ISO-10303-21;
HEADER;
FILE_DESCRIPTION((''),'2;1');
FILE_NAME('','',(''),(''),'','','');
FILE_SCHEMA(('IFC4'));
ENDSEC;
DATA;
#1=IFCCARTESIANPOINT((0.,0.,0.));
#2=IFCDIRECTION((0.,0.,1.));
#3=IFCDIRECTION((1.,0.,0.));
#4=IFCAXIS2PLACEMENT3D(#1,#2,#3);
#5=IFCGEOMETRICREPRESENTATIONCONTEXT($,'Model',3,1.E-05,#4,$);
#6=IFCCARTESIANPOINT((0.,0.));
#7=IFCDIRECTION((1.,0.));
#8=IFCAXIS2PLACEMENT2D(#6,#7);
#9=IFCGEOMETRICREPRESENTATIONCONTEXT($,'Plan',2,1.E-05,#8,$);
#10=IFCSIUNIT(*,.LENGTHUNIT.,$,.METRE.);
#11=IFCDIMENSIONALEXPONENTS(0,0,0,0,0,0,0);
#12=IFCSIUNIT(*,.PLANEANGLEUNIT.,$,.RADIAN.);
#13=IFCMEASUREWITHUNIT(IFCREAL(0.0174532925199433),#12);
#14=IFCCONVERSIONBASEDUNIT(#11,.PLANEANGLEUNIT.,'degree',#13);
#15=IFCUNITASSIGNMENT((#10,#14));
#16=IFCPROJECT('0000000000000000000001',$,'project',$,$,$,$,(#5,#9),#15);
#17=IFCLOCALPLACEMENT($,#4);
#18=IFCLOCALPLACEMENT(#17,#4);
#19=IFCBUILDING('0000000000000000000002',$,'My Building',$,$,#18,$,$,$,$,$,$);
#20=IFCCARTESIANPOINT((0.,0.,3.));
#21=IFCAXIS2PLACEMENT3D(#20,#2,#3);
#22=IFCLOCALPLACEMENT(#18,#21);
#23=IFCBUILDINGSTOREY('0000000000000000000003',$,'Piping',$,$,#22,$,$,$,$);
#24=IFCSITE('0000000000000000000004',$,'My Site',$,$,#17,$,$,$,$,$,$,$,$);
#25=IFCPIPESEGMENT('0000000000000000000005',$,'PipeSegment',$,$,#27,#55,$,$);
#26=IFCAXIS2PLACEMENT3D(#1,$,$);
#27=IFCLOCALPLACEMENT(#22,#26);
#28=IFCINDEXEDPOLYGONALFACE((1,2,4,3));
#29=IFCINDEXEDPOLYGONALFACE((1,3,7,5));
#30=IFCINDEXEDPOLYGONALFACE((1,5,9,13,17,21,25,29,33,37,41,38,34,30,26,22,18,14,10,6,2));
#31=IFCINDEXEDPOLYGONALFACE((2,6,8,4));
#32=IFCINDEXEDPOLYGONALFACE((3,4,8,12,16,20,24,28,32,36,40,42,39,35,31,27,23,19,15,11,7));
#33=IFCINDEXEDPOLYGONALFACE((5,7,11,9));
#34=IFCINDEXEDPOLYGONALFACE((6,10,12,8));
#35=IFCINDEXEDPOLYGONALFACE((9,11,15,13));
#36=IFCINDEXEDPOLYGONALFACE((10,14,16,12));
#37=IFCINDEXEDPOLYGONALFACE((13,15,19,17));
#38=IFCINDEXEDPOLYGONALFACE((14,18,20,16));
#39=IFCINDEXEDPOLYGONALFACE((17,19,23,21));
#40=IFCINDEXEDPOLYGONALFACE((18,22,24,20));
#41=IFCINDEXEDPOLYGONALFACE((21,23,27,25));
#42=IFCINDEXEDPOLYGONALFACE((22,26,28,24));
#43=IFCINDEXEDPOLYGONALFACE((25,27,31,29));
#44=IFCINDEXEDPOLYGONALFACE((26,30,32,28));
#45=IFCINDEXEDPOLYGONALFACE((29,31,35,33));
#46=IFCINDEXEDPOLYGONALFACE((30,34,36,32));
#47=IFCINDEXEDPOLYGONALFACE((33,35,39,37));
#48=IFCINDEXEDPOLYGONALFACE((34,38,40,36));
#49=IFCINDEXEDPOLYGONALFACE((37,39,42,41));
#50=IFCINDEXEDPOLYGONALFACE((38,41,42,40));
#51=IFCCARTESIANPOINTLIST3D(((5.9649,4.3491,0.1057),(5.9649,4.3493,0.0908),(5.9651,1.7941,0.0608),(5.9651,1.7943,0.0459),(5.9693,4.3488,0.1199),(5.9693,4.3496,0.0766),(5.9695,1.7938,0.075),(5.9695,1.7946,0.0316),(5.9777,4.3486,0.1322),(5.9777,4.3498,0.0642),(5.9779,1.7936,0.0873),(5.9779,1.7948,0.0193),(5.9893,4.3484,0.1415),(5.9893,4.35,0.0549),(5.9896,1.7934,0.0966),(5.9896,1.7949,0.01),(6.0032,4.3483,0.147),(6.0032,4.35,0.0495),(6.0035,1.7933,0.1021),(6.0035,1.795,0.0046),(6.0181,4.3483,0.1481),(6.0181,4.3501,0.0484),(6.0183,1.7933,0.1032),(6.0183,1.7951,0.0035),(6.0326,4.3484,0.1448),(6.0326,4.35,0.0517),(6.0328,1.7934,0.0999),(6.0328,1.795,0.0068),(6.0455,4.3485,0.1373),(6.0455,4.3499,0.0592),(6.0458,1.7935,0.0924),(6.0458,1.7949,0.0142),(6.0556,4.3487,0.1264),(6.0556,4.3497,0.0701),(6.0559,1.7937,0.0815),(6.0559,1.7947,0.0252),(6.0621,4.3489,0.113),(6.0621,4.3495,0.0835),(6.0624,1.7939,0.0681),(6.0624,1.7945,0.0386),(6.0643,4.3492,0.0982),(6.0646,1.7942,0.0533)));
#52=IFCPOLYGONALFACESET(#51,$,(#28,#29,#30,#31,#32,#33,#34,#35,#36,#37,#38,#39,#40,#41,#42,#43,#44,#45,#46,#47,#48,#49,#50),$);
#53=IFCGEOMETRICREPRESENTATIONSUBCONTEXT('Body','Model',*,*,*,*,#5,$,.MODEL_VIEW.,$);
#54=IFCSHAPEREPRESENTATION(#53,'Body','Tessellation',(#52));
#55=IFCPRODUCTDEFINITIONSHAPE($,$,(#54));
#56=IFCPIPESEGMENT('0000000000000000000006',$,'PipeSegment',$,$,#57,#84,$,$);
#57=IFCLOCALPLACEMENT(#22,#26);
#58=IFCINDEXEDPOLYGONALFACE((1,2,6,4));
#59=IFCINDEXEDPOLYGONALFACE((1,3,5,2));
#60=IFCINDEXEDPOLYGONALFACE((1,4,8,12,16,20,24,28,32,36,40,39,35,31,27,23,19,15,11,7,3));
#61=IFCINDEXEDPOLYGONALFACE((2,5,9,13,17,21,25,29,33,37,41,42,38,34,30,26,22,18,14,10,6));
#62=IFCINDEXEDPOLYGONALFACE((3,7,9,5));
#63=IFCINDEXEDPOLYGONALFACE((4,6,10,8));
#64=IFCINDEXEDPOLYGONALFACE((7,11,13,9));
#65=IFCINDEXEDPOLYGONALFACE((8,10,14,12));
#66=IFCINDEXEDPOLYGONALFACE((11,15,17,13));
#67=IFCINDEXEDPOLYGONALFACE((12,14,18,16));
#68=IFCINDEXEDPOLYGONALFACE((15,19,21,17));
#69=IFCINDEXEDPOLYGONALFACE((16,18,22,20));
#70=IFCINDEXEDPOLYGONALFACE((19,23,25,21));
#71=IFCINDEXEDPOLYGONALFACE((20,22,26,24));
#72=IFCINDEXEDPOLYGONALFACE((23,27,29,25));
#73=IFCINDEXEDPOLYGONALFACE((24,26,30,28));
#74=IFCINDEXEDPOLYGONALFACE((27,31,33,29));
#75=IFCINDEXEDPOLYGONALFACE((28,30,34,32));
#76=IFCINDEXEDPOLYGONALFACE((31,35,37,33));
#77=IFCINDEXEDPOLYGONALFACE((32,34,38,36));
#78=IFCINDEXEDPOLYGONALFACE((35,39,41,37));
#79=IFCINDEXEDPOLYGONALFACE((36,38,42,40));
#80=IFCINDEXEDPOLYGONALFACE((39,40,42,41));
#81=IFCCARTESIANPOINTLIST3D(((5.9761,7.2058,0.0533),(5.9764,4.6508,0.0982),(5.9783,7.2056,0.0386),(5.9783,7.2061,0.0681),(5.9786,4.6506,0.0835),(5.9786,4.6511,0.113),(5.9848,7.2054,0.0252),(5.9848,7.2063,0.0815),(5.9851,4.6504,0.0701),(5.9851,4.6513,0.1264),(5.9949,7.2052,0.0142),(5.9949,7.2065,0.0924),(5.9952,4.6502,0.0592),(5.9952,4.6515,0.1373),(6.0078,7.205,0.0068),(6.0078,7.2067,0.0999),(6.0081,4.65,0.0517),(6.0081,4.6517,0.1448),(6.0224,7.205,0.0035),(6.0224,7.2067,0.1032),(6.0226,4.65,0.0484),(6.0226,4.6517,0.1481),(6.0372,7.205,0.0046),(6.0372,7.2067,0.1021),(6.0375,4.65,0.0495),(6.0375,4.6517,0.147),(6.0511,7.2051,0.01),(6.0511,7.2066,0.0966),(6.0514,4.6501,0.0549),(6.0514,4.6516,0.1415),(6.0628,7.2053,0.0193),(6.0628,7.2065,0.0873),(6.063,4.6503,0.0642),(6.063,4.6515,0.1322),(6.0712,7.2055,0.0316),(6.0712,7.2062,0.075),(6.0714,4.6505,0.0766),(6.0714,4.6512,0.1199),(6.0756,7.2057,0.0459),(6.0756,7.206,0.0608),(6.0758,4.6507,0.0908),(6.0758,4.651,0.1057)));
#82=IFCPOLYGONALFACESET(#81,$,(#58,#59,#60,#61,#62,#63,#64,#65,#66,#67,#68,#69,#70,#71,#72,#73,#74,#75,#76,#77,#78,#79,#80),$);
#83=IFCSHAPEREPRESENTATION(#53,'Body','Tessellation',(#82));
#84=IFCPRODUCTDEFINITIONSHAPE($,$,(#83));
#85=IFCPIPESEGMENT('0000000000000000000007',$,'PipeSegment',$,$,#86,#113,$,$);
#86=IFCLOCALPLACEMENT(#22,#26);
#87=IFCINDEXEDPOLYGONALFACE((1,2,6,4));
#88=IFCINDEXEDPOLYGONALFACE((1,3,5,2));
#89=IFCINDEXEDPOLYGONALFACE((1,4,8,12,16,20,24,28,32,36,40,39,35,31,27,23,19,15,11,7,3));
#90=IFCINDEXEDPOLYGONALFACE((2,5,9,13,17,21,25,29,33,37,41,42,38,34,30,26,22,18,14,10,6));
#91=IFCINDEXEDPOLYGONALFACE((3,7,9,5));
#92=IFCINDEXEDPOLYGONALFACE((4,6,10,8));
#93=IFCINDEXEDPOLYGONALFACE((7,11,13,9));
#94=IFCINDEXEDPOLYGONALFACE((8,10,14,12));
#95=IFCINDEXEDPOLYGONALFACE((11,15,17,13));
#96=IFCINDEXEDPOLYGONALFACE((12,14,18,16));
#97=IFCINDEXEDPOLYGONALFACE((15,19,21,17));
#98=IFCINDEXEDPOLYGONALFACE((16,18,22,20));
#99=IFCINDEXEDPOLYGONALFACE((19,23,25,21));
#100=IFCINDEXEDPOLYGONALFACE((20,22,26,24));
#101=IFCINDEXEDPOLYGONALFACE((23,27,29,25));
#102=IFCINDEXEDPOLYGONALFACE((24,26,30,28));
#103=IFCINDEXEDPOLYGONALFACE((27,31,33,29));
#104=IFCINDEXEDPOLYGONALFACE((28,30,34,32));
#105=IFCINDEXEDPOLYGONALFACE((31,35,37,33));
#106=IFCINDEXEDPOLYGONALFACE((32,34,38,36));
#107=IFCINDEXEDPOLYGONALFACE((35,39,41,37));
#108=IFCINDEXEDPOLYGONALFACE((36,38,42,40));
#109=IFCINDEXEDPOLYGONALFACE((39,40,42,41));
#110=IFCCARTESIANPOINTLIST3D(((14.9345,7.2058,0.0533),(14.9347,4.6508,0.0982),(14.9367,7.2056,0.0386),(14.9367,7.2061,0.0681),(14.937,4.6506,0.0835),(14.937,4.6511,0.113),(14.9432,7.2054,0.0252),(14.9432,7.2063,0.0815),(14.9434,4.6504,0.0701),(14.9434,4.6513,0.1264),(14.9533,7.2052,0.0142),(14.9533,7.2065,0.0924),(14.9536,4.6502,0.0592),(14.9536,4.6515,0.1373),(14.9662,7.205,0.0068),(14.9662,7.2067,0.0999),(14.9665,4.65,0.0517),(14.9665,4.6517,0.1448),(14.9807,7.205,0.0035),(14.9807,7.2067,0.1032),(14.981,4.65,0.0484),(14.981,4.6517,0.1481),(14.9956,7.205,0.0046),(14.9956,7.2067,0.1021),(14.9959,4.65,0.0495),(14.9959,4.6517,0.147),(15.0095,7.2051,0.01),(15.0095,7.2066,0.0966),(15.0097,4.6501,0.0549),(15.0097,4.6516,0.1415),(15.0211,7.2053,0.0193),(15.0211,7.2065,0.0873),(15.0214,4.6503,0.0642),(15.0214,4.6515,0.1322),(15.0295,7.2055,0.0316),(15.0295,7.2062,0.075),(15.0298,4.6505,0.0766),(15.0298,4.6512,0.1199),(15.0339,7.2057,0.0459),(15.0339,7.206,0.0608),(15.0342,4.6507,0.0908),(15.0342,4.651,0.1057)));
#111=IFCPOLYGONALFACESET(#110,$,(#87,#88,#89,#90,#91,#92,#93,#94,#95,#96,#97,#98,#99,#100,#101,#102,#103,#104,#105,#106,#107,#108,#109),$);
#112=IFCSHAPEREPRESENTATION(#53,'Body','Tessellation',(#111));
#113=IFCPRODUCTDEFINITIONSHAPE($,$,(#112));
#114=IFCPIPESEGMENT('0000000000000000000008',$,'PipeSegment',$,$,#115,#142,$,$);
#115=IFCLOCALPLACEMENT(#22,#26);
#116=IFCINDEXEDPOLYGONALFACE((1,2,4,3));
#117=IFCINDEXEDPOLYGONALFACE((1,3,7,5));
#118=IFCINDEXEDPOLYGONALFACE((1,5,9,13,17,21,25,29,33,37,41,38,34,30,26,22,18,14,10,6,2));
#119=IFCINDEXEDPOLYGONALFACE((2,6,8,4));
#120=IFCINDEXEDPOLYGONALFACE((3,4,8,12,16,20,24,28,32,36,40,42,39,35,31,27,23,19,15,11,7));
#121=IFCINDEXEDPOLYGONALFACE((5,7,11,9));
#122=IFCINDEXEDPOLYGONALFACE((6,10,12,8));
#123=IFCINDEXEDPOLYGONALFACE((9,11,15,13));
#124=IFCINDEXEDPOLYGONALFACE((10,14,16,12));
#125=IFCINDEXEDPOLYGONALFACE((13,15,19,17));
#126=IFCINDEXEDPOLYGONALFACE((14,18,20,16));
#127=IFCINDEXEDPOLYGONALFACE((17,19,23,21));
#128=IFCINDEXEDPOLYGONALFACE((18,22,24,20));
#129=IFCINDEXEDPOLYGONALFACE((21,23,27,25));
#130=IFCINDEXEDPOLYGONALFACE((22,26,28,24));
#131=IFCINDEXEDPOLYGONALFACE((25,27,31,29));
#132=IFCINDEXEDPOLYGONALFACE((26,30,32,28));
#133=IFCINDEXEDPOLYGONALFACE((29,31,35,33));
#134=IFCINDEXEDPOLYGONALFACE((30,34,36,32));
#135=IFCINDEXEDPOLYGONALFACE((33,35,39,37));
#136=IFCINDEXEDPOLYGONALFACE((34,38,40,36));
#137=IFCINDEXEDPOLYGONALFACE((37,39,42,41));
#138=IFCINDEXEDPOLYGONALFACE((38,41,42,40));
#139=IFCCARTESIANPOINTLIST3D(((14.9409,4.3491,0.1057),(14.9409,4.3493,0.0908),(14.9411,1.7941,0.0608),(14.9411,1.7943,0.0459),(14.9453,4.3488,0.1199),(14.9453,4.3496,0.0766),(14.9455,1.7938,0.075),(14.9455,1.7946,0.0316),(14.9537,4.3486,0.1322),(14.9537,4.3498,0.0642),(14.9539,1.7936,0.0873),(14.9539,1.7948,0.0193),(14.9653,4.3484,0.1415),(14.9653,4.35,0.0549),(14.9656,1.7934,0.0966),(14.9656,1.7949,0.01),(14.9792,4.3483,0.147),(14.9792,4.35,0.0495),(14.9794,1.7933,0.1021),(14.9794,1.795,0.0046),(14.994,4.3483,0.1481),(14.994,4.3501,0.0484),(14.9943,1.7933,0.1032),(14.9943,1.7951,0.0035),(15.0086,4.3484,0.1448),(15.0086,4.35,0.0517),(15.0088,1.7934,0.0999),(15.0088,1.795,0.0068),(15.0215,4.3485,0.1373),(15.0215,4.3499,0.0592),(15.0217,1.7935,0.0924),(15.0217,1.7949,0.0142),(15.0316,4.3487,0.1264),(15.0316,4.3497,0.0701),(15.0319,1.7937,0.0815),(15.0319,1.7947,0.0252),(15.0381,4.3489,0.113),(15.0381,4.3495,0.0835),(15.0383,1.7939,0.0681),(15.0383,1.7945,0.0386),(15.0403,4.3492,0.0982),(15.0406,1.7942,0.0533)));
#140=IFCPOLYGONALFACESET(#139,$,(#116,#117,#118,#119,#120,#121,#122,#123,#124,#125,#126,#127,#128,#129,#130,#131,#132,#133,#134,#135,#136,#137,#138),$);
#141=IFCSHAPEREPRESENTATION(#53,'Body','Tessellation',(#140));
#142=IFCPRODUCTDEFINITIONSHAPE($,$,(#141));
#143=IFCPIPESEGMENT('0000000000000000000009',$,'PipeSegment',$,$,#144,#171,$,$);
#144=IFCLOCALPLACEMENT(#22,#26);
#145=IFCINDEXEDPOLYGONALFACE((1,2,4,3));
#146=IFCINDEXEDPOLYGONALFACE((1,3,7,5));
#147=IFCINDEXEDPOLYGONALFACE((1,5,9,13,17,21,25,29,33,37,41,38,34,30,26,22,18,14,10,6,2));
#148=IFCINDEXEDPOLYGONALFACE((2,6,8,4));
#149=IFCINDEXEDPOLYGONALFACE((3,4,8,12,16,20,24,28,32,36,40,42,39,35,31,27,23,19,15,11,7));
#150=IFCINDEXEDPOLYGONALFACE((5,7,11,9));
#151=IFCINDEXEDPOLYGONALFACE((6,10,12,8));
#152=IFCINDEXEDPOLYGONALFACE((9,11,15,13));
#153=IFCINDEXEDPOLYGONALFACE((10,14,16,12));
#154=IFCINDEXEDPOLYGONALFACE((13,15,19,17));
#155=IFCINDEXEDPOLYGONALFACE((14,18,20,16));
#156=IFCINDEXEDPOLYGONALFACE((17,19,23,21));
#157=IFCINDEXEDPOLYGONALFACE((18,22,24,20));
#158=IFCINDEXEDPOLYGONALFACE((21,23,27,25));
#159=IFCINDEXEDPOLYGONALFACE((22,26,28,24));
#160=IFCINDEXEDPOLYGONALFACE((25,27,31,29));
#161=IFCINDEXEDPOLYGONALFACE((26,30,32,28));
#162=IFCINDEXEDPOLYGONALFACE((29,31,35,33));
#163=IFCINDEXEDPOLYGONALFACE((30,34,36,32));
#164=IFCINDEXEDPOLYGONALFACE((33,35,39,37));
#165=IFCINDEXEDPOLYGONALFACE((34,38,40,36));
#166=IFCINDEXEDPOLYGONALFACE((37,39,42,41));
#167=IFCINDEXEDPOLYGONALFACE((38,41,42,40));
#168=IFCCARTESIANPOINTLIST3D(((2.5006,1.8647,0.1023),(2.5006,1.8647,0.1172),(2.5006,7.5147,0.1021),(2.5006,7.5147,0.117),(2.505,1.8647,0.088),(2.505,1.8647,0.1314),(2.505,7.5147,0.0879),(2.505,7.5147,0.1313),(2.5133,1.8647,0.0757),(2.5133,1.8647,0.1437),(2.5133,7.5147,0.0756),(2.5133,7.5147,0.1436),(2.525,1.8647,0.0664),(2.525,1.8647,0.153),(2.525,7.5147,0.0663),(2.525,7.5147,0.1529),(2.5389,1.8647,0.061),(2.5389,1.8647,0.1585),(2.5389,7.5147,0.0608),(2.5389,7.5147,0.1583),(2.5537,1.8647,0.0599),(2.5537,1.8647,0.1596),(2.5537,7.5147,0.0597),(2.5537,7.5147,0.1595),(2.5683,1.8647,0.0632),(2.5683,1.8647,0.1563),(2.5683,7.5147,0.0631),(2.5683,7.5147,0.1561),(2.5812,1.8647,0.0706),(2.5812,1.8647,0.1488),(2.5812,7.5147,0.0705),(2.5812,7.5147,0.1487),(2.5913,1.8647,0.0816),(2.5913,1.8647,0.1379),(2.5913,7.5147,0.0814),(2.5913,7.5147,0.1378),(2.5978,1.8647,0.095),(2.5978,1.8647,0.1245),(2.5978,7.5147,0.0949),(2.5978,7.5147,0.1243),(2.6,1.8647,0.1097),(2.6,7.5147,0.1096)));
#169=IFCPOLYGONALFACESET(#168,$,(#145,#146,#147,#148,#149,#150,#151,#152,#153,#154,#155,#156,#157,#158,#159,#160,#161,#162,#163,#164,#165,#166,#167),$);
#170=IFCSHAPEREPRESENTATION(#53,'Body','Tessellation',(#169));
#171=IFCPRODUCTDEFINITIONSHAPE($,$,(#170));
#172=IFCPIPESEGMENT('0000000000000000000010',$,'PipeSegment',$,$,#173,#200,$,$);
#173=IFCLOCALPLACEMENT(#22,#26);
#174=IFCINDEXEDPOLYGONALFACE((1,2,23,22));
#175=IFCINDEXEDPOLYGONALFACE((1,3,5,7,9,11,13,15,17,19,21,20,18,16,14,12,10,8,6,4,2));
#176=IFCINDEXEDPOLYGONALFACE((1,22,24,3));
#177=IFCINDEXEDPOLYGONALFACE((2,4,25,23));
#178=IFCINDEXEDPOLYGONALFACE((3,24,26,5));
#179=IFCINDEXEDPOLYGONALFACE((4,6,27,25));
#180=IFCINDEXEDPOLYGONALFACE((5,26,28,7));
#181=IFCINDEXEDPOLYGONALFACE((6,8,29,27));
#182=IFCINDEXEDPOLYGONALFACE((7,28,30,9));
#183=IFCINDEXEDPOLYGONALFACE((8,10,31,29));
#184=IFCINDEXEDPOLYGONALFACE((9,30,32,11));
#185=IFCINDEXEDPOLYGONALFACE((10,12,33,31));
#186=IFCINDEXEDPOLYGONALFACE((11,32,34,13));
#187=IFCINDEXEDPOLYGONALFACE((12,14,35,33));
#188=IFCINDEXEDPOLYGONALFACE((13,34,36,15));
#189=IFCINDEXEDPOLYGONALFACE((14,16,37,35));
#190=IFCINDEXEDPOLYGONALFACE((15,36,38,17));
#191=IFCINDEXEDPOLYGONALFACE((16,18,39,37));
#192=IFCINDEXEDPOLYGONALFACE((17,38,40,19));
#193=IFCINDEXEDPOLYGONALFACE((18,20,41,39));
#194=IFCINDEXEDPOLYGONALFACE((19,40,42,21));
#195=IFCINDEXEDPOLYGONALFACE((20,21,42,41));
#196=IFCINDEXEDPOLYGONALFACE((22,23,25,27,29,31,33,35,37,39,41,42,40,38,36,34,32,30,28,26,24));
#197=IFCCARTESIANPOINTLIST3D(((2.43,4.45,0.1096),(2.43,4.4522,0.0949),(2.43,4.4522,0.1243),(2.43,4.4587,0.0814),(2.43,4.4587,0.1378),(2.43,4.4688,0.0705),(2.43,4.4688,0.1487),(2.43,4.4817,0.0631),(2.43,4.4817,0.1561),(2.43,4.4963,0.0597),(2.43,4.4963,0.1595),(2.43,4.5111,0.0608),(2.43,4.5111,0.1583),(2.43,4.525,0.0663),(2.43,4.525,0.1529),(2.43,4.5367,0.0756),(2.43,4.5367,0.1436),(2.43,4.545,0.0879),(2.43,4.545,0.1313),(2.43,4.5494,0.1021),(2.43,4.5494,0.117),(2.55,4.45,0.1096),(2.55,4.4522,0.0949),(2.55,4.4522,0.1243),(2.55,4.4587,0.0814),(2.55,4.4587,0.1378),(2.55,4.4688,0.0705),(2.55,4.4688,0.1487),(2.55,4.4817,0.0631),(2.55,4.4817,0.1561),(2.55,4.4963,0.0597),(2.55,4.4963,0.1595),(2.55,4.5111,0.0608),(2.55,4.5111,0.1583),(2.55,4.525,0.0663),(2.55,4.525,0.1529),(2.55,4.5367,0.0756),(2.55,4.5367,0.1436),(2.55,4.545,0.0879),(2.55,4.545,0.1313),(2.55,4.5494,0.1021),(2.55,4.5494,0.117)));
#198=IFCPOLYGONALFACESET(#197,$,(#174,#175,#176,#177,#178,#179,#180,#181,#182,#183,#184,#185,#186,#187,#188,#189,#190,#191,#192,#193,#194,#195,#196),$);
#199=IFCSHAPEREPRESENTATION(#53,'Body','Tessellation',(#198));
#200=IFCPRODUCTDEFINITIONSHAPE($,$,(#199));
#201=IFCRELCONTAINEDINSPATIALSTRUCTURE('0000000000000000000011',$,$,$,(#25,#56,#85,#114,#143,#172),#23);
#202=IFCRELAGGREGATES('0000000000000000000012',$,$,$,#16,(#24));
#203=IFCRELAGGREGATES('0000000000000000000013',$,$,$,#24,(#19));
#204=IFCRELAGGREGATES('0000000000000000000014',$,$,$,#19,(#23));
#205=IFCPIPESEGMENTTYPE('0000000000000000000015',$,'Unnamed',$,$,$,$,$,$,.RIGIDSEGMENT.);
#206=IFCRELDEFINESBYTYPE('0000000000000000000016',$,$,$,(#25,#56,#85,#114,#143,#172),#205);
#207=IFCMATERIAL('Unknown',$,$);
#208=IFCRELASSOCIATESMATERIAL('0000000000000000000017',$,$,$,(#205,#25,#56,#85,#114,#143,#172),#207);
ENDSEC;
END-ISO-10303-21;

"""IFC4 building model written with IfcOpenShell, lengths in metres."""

from ifc_helpers import new_model, entity, si_unit, converted_unit, frame, origin_with_axes, origin_2d_with_axis, place, context, subcontext, project, spatial, circle, extrude, material, material_profile, profile_set, profile_usage, type_object, element, save


model = new_model("IFC4")

# Units and contexts
model_context = context("Model", 3, precision=1e-05, world=origin_with_axes())
plan_context = context("Plan", 2, precision=1e-05, world=origin_2d_with_axis())
body_context = subcontext(model_context, "Body", "Model", "MODEL_VIEW")
ifc_project = project(units=[si_unit("LENGTHUNIT", "METRE"), converted_unit("PLANEANGLEUNIT", "degree", entity("IfcReal", 0.0174532925199433), si_unit("PLANEANGLEUNIT", "RADIAN"), dimensions=[0, 0, 0, 0, 0, 0, 0])], contexts=[model_context, plan_context])

# Site, building, storey
site_placement = place(None, origin_with_axes())
site = spatial("IfcSite", under=ifc_project, at=site_placement, Name="My Site")
building_placement = place(site_placement, origin_with_axes())
building = spatial("IfcBuilding", under=site, at=building_placement, Name="My Building")
storey_placement = place(building_placement, frame((0.0, 0.0, 3.0), z_axis=(0.0, 0.0, 1.0), x_axis=(1.0, 0.0, 0.0)))
storey = spatial("IfcBuildingStorey", under=building, at=storey_placement, Name="Piping")

# Pipe segments
ifc_material = material(Name="Unknown")
ifc_material_profile_1 = material_profile(ifc_material, circle(Radius=0.05))
ifc_profile_set_1 = profile_set([ifc_material_profile_1])
pipe_segment_type = type_object("IfcPipeSegmentType", Name="Unnamed", PredefinedType="RIGIDSEGMENT", material=ifc_profile_set_1)
ifc_profile_usage_1 = profile_usage(ifc_profile_set_1, cardinal=5)
pipe_segment_1_placement = place(storey_placement, frame((6.0143, 4.3492, 0.0982), z_axis=(0.000099, -0.999846, -0.017575), x_axis=(1.0, 0.000099, -0.000001)))
element("IfcPipeSegment", 1, at=pipe_segment_1_placement, inside=storey, type_object=pipe_segment_type, material=ifc_profile_usage_1, Name="PipeSegment", context=body_context, shape_type="SweptSolid", body=[
    extrude(circle(Radius=0.05), origin_with_axes(), (0.0, 0.0, 1.0), 2.5554),
])
ifc_profile_usage_2 = profile_usage(ifc_profile_set_1, cardinal=5)
pipe_segment_2_placement = place(storey_placement, frame((6.0264, 4.6508, 0.0982), z_axis=(-0.000099, 0.999846, -0.017575), x_axis=(-1.0, -0.000099, 0.0)))
element("IfcPipeSegment", 2, at=pipe_segment_2_placement, inside=storey, type_object=pipe_segment_type, material=ifc_profile_usage_2, Name="PipeSegment", context=body_context, shape_type="SweptSolid", body=[
    extrude(circle(Radius=0.05), origin_with_axes(), (0.0, 0.0, 1.0), 2.5554),
])
ifc_profile_usage_3 = profile_usage(ifc_profile_set_1, cardinal=5)
pipe_segment_3_placement = place(storey_placement, frame((14.9847, 4.6508, 0.0982), z_axis=(-0.000099, 0.999846, -0.017575), x_axis=(-1.0, -0.000099, 0.0)))
element("IfcPipeSegment", 3, at=pipe_segment_3_placement, inside=storey, type_object=pipe_segment_type, material=ifc_profile_usage_3, Name="PipeSegment", context=body_context, shape_type="SweptSolid", body=[
    extrude(circle(Radius=0.05), origin_with_axes(), (0.0, 0.0, 1.0), 2.5554),
])
ifc_profile_usage_4 = profile_usage(ifc_profile_set_1, cardinal=5)
pipe_segment_4_placement = place(storey_placement, frame((14.9903, 4.3492, 0.0982), z_axis=(0.000099, -0.999846, -0.017575), x_axis=(1.0, 0.000099, -0.000001)))
element("IfcPipeSegment", 4, at=pipe_segment_4_placement, inside=storey, type_object=pipe_segment_type, material=ifc_profile_usage_4, Name="PipeSegment", context=body_context, shape_type="SweptSolid", body=[
    extrude(circle(Radius=0.05), origin_with_axes(), (0.0, 0.0, 1.0), 2.5554),
])
ifc_profile_usage_5 = profile_usage(ifc_profile_set_1, cardinal=5)
pipe_segment_5_placement = place(storey_placement, frame((2.55, 7.5147, 0.1096), z_axis=(0.0, -1.0, 0.000021), x_axis=(1.0, 0.0, 0.0)))
element("IfcPipeSegment", 5, at=pipe_segment_5_placement, inside=storey, type_object=pipe_segment_type, material=ifc_profile_usage_5, Name="PipeSegment", context=body_context, shape_type="SweptSolid", body=[
    extrude(circle(Radius=0.05), origin_with_axes(), (0.0, 0.0, 1.0), 5.65),
])
ifc_profile_usage_6 = profile_usage(ifc_profile_set_1, cardinal=5)
pipe_segment_6_placement = place(storey_placement, frame((2.55, 4.5, 0.1096), z_axis=(-1.0, 0.0, 0.0), x_axis=(0.0, -1.0, 0.0)))
element("IfcPipeSegment", 6, at=pipe_segment_6_placement, inside=storey, type_object=pipe_segment_type, material=ifc_profile_usage_6, Name="PipeSegment", context=body_context, shape_type="SweptSolid", body=[
    extrude(circle(Radius=0.05), origin_with_axes(), (0.0, 0.0, 1.0), 0.12),
])

save(model, "model.ifc")
